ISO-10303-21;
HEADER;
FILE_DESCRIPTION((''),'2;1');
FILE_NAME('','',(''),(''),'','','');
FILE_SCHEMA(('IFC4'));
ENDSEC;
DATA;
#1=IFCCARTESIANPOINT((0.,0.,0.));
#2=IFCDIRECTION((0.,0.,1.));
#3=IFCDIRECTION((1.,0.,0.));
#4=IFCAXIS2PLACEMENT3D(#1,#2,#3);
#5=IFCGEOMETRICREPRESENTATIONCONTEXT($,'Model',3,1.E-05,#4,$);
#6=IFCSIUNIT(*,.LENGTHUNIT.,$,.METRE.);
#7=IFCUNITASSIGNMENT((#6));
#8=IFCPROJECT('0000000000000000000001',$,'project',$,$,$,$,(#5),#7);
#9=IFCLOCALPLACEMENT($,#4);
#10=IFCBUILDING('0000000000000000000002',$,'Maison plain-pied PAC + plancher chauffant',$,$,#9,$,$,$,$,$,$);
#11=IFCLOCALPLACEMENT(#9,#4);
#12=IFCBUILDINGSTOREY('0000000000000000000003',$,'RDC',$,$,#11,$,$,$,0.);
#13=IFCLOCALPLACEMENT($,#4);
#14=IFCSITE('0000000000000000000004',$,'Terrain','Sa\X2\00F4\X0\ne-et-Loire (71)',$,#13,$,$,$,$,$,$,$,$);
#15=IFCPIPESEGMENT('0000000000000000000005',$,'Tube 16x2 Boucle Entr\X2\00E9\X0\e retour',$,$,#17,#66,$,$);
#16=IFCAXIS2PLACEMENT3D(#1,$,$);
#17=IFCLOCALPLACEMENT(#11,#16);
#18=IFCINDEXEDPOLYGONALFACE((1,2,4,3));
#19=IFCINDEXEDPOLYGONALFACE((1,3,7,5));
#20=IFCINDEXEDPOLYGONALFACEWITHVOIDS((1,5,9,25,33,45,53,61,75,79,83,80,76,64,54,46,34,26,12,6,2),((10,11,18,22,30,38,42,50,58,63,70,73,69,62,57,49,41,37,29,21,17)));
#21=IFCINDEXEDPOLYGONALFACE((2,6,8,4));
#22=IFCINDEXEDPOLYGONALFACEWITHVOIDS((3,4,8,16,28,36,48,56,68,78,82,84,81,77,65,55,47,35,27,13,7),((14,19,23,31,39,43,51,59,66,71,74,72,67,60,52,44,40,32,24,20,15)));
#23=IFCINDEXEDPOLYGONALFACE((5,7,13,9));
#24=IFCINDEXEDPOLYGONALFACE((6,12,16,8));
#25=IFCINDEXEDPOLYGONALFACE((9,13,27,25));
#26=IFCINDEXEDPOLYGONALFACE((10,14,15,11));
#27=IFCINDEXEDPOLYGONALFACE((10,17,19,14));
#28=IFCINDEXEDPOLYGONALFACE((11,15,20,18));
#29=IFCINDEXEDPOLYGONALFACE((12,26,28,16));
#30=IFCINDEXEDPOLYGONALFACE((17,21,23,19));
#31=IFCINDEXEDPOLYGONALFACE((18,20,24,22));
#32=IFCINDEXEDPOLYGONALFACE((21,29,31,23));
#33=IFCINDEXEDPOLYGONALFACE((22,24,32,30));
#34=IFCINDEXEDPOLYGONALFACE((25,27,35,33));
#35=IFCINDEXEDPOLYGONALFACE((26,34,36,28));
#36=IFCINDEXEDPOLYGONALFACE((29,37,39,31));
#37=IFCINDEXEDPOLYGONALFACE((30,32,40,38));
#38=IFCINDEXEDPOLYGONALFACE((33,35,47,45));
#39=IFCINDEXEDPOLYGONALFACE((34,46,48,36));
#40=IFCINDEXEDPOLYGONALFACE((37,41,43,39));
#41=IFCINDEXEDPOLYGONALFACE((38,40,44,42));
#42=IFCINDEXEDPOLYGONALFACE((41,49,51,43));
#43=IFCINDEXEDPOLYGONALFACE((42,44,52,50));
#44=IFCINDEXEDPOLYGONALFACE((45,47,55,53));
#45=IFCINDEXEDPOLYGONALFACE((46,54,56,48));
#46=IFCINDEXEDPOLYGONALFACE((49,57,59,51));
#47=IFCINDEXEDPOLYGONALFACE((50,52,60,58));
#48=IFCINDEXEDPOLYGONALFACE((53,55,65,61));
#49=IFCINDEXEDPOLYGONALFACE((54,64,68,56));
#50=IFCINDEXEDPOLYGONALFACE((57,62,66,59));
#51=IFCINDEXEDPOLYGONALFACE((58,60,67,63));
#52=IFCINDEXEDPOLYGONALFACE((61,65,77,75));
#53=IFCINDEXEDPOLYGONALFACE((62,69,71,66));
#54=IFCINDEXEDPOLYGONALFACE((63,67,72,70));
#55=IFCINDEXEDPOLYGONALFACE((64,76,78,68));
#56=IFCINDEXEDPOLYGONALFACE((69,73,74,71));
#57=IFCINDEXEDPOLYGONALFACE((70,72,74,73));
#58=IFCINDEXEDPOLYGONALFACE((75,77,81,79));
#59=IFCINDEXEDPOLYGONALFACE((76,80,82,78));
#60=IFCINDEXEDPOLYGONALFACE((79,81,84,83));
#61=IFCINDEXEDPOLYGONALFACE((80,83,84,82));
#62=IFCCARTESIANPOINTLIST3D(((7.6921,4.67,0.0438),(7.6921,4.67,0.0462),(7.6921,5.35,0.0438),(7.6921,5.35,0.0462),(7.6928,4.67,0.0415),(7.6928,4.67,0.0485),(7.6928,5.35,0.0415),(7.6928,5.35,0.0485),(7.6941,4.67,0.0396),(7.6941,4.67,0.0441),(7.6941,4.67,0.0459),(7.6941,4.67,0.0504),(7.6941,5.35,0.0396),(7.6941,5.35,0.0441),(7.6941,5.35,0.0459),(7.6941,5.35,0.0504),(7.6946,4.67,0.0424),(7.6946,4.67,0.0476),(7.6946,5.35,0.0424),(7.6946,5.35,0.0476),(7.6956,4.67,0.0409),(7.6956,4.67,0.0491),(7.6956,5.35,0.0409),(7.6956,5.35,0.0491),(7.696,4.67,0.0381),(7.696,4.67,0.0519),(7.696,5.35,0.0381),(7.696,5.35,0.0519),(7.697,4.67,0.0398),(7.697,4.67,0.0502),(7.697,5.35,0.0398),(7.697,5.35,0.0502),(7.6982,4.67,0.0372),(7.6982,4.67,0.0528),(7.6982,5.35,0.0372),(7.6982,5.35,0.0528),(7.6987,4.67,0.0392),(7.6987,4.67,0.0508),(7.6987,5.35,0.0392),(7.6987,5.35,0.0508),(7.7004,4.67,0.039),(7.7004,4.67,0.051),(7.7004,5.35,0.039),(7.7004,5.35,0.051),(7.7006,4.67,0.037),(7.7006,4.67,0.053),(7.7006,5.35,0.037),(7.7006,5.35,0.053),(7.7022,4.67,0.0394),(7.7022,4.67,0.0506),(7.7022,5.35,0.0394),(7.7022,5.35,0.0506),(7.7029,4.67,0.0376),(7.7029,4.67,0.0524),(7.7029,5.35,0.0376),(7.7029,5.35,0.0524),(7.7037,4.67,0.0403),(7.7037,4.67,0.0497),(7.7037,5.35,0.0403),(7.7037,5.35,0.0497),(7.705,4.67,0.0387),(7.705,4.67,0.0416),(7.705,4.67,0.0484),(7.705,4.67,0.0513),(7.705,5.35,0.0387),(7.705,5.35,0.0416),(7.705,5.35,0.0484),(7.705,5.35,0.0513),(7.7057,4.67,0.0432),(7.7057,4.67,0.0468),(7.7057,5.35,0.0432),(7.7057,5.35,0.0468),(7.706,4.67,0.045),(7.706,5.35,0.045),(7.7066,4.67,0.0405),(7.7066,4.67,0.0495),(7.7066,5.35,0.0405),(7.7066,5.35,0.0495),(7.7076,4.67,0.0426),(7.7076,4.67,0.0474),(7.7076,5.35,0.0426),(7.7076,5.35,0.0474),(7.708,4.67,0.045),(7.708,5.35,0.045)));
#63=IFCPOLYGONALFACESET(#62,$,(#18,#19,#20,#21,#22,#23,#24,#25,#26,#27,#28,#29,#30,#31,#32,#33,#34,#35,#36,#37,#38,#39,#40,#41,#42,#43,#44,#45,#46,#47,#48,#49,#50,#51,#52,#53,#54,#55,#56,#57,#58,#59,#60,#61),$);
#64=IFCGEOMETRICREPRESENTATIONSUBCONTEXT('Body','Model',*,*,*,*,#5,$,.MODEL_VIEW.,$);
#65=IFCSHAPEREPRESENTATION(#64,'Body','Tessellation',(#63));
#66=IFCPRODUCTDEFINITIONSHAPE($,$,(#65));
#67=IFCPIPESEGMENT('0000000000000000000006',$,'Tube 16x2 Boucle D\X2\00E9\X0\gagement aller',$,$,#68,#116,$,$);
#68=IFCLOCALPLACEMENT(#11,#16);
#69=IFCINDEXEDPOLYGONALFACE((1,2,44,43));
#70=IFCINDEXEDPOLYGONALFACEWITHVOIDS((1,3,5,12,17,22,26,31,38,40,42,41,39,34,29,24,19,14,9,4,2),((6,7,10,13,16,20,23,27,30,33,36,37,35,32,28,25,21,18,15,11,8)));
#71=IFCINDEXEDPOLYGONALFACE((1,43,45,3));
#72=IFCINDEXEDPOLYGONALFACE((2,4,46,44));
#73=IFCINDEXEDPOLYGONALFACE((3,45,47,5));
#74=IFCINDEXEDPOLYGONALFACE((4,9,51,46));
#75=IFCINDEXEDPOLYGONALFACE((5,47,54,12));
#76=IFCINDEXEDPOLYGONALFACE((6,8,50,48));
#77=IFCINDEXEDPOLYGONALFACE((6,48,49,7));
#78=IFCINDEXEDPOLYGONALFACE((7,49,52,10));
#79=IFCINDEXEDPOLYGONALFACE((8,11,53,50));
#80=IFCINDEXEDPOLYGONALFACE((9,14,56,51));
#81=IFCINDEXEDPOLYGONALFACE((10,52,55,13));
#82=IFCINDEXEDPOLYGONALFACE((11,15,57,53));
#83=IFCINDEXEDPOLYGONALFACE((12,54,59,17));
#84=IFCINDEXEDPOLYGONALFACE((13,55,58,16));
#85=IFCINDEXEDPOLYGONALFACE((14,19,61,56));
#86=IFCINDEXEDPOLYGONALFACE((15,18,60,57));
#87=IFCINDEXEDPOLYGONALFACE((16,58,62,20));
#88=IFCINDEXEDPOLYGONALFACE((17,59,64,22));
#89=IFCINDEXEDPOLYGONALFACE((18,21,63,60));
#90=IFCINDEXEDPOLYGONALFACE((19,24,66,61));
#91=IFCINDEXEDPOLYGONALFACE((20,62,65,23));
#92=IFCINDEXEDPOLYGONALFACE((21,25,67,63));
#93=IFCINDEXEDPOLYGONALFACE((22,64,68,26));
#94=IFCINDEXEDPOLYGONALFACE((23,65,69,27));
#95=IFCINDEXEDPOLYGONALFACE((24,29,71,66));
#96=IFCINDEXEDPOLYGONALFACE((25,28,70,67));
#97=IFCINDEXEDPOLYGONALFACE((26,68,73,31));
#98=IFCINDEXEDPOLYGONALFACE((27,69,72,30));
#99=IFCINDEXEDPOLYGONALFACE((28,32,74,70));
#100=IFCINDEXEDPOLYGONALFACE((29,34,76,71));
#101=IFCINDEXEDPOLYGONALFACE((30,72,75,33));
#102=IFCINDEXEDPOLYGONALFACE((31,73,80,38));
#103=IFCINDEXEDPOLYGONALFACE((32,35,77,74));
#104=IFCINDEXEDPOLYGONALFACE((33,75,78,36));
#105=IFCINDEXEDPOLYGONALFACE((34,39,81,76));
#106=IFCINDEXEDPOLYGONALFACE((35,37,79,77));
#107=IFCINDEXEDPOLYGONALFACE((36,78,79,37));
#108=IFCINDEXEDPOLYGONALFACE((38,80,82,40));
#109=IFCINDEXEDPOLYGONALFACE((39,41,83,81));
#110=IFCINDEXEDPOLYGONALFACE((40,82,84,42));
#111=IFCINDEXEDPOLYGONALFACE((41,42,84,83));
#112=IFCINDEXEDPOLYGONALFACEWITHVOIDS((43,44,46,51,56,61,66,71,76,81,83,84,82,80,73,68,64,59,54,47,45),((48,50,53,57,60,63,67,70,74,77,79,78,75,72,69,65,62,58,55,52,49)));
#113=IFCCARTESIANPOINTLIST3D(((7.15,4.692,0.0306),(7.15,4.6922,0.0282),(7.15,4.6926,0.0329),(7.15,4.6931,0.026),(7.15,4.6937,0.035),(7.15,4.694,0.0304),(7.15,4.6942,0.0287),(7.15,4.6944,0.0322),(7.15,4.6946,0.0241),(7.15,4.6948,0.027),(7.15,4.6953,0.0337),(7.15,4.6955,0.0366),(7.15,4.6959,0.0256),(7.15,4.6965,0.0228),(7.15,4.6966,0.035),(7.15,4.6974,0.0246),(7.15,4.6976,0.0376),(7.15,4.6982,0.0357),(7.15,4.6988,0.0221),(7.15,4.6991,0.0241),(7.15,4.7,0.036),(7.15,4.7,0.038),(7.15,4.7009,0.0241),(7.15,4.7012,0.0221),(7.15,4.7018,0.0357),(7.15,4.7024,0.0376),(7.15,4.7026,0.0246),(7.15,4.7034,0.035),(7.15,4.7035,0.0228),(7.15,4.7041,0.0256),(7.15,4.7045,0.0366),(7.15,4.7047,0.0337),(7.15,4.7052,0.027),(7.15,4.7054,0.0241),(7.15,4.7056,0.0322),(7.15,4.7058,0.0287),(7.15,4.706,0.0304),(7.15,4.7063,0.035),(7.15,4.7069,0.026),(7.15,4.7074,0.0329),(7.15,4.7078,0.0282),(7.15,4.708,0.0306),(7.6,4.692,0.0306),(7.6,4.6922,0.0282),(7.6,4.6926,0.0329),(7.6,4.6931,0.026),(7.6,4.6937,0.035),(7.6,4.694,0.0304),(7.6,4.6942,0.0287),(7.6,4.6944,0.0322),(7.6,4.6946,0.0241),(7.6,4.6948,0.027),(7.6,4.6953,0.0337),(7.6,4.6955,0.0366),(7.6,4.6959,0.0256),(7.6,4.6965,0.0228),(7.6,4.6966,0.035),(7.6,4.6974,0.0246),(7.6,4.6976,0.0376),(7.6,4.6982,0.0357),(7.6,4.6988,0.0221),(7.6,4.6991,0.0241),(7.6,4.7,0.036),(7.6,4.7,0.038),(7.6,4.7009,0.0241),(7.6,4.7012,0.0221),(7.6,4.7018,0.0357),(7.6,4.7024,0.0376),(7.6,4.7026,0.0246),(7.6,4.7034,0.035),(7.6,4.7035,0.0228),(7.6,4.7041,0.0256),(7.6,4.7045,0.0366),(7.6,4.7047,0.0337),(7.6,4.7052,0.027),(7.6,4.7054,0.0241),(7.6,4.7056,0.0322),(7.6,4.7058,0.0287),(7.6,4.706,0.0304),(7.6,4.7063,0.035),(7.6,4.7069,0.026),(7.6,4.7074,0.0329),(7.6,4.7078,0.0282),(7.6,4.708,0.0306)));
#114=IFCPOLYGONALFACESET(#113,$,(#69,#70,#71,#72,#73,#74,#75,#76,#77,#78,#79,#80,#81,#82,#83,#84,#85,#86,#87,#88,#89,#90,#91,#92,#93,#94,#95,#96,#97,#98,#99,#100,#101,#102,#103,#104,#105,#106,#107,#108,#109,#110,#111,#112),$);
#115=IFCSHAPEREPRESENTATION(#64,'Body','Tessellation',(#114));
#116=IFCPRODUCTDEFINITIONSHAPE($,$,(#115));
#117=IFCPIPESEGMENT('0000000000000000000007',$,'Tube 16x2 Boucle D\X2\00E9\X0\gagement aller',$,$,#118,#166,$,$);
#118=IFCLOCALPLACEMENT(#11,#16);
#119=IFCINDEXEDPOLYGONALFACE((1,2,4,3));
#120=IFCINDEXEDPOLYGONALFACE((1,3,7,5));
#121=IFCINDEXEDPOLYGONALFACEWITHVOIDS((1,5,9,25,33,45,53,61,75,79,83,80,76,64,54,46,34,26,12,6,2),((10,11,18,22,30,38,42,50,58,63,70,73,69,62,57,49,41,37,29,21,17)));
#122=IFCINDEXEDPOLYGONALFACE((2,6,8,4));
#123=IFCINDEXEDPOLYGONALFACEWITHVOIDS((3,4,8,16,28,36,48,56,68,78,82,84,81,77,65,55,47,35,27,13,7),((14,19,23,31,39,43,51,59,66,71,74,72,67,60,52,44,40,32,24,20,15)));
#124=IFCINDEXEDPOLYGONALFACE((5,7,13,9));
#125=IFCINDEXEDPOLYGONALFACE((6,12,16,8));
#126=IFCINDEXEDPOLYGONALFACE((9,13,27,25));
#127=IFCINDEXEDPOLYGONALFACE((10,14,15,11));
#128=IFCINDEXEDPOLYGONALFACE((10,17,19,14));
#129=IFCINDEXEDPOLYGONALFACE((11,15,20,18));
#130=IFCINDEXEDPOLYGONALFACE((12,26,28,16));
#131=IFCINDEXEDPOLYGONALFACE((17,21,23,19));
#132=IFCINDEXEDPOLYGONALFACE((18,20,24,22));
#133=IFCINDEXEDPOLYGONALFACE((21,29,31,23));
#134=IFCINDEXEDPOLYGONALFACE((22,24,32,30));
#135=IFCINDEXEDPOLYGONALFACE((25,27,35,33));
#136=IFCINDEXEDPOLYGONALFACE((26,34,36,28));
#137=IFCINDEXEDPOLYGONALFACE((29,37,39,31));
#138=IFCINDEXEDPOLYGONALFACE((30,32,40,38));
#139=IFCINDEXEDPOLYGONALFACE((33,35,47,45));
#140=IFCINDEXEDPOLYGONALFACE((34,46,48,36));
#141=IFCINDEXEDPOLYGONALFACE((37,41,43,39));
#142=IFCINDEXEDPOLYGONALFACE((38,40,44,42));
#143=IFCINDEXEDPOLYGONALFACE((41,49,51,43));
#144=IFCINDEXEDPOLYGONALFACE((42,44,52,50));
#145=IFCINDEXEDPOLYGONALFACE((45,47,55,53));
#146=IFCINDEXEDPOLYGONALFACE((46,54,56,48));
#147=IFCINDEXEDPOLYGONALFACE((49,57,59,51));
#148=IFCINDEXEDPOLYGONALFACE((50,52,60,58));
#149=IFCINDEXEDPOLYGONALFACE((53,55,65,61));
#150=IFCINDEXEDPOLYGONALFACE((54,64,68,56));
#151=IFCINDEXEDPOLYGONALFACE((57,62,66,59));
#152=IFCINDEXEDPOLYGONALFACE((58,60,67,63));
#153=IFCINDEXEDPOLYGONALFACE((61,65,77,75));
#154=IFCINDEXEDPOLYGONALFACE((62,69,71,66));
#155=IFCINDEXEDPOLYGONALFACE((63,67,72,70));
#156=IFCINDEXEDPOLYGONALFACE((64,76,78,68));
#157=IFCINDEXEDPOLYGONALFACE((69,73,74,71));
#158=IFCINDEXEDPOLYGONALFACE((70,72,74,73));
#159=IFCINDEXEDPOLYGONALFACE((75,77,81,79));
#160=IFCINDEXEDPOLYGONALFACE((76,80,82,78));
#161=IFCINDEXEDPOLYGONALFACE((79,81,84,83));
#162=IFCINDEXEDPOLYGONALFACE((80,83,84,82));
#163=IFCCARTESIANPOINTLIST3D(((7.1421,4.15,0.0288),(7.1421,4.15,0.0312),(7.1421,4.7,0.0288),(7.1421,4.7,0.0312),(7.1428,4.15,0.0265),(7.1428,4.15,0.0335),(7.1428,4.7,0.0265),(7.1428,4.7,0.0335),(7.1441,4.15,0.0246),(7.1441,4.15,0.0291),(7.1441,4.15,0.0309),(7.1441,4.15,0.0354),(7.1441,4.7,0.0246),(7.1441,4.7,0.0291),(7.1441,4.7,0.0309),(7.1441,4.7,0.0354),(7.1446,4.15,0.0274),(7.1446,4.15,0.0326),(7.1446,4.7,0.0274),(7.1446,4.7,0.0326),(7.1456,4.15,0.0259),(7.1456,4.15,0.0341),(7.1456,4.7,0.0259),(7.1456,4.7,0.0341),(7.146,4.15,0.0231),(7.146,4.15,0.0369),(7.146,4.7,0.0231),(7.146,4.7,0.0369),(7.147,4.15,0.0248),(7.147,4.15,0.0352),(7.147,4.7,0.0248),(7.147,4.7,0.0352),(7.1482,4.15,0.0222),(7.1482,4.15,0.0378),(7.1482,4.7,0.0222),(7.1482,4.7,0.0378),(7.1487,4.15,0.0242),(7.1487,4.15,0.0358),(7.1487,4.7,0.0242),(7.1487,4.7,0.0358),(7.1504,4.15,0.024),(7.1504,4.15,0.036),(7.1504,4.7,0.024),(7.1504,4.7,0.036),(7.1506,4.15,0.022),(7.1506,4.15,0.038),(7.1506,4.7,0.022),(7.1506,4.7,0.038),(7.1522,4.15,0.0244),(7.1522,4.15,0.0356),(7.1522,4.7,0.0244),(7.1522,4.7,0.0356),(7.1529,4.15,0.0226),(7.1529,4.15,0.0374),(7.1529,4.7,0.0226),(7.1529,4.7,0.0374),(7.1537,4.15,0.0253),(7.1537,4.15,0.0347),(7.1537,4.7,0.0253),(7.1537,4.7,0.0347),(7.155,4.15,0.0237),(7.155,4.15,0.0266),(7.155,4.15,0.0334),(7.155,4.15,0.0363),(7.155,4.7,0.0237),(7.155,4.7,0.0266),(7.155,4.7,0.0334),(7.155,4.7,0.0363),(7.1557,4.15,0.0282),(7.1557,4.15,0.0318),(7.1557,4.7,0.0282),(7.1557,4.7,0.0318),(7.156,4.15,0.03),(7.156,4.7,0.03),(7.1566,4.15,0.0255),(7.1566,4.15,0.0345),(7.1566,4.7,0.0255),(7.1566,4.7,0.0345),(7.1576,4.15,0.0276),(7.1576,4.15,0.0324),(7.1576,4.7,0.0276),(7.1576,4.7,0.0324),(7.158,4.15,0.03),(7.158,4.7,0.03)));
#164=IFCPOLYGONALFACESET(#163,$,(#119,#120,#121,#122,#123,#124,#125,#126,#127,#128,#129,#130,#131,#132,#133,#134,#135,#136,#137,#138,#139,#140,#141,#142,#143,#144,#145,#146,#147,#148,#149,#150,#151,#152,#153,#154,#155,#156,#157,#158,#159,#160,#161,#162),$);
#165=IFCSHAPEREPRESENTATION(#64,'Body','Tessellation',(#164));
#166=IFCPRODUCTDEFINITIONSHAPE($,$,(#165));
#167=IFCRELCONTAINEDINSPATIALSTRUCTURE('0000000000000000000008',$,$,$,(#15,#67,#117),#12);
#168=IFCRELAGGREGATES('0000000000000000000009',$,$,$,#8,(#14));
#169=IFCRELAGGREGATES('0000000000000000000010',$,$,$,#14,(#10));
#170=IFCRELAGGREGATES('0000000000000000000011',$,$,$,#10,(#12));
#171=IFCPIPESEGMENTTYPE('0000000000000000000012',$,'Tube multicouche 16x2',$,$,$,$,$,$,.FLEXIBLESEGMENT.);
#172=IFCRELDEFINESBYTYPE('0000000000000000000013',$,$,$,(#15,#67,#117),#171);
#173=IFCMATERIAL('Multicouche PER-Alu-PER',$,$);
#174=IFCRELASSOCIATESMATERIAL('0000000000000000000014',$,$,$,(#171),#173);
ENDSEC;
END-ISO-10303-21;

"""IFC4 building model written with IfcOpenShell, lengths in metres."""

from ifc_helpers import new_model, si_unit, frame, origin_with_axes, place, context, subcontext, project, spatial, hollow_circle, extrude, material, type_object, element, save


model = new_model("IFC4")

# Units and contexts
model_context = context("Model", 3, precision=1e-05, world=origin_with_axes())
body_context = subcontext(model_context, "Body", "Model", "MODEL_VIEW")
ifc_project = project(units=[si_unit("LENGTHUNIT", "METRE")], contexts=[model_context])

# Site, building, storey
site_placement = place(None, origin_with_axes())
site = spatial("IfcSite", under=ifc_project, at=site_placement, Name="Terrain", Description="Saône-et-Loire (71)")
building_placement = place(None, origin_with_axes())
building = spatial("IfcBuilding", under=site, at=building_placement, Name="Maison plain-pied PAC + plancher chauffant")
storey_placement = place(building_placement, origin_with_axes())
storey = spatial("IfcBuildingStorey", under=building, at=storey_placement, Name="RDC", Elevation=0.0)

# Pipe segments
ifc_material = material(Name="Multicouche PER-Alu-PER")
pipe_segment_type = type_object("IfcPipeSegmentType", Name="Tube multicouche 16x2", PredefinedType="FLEXIBLESEGMENT", material=ifc_material)
pipe_segment_1_placement = place(storey_placement, frame((7.7, 4.67, 0.045), z_axis=(0.0, 1.0, 0.0), x_axis=(1.0, 0.0, 0.0)))
element("IfcPipeSegment", 1, at=pipe_segment_1_placement, inside=storey, type_object=pipe_segment_type, Name="Tube 16x2 Boucle Entrée retour", context=body_context, shape_type="SweptSolid", body=[
    extrude(hollow_circle(Radius=0.008, WallThickness=0.002), origin_with_axes(), (0.0, 0.0, 1.0), 0.68),
])
pipe_segment_2_placement = place(storey_placement, frame((7.6, 4.7, 0.03), z_axis=(-1.0, 0.0, 0.0), x_axis=(0.0, 0.0, 1.0)))
element("IfcPipeSegment", 2, at=pipe_segment_2_placement, inside=storey, type_object=pipe_segment_type, Name="Tube 16x2 Boucle Dégagement aller", context=body_context, shape_type="SweptSolid", body=[
    extrude(hollow_circle(Radius=0.008, WallThickness=0.002), origin_with_axes(), (0.0, 0.0, 1.0), 0.45),
])
pipe_segment_3_placement = place(storey_placement, frame((7.15, 4.7, 0.03), z_axis=(0.0, -1.0, 0.0), x_axis=(1.0, 0.0, 0.0)))
element("IfcPipeSegment", 3, at=pipe_segment_3_placement, inside=storey, type_object=pipe_segment_type, Name="Tube 16x2 Boucle Dégagement aller", context=body_context, shape_type="SweptSolid", body=[
    extrude(hollow_circle(Radius=0.008, WallThickness=0.002), origin_with_axes(), (0.0, 0.0, 1.0), 0.55),
])

save(model, "model.ifc")
